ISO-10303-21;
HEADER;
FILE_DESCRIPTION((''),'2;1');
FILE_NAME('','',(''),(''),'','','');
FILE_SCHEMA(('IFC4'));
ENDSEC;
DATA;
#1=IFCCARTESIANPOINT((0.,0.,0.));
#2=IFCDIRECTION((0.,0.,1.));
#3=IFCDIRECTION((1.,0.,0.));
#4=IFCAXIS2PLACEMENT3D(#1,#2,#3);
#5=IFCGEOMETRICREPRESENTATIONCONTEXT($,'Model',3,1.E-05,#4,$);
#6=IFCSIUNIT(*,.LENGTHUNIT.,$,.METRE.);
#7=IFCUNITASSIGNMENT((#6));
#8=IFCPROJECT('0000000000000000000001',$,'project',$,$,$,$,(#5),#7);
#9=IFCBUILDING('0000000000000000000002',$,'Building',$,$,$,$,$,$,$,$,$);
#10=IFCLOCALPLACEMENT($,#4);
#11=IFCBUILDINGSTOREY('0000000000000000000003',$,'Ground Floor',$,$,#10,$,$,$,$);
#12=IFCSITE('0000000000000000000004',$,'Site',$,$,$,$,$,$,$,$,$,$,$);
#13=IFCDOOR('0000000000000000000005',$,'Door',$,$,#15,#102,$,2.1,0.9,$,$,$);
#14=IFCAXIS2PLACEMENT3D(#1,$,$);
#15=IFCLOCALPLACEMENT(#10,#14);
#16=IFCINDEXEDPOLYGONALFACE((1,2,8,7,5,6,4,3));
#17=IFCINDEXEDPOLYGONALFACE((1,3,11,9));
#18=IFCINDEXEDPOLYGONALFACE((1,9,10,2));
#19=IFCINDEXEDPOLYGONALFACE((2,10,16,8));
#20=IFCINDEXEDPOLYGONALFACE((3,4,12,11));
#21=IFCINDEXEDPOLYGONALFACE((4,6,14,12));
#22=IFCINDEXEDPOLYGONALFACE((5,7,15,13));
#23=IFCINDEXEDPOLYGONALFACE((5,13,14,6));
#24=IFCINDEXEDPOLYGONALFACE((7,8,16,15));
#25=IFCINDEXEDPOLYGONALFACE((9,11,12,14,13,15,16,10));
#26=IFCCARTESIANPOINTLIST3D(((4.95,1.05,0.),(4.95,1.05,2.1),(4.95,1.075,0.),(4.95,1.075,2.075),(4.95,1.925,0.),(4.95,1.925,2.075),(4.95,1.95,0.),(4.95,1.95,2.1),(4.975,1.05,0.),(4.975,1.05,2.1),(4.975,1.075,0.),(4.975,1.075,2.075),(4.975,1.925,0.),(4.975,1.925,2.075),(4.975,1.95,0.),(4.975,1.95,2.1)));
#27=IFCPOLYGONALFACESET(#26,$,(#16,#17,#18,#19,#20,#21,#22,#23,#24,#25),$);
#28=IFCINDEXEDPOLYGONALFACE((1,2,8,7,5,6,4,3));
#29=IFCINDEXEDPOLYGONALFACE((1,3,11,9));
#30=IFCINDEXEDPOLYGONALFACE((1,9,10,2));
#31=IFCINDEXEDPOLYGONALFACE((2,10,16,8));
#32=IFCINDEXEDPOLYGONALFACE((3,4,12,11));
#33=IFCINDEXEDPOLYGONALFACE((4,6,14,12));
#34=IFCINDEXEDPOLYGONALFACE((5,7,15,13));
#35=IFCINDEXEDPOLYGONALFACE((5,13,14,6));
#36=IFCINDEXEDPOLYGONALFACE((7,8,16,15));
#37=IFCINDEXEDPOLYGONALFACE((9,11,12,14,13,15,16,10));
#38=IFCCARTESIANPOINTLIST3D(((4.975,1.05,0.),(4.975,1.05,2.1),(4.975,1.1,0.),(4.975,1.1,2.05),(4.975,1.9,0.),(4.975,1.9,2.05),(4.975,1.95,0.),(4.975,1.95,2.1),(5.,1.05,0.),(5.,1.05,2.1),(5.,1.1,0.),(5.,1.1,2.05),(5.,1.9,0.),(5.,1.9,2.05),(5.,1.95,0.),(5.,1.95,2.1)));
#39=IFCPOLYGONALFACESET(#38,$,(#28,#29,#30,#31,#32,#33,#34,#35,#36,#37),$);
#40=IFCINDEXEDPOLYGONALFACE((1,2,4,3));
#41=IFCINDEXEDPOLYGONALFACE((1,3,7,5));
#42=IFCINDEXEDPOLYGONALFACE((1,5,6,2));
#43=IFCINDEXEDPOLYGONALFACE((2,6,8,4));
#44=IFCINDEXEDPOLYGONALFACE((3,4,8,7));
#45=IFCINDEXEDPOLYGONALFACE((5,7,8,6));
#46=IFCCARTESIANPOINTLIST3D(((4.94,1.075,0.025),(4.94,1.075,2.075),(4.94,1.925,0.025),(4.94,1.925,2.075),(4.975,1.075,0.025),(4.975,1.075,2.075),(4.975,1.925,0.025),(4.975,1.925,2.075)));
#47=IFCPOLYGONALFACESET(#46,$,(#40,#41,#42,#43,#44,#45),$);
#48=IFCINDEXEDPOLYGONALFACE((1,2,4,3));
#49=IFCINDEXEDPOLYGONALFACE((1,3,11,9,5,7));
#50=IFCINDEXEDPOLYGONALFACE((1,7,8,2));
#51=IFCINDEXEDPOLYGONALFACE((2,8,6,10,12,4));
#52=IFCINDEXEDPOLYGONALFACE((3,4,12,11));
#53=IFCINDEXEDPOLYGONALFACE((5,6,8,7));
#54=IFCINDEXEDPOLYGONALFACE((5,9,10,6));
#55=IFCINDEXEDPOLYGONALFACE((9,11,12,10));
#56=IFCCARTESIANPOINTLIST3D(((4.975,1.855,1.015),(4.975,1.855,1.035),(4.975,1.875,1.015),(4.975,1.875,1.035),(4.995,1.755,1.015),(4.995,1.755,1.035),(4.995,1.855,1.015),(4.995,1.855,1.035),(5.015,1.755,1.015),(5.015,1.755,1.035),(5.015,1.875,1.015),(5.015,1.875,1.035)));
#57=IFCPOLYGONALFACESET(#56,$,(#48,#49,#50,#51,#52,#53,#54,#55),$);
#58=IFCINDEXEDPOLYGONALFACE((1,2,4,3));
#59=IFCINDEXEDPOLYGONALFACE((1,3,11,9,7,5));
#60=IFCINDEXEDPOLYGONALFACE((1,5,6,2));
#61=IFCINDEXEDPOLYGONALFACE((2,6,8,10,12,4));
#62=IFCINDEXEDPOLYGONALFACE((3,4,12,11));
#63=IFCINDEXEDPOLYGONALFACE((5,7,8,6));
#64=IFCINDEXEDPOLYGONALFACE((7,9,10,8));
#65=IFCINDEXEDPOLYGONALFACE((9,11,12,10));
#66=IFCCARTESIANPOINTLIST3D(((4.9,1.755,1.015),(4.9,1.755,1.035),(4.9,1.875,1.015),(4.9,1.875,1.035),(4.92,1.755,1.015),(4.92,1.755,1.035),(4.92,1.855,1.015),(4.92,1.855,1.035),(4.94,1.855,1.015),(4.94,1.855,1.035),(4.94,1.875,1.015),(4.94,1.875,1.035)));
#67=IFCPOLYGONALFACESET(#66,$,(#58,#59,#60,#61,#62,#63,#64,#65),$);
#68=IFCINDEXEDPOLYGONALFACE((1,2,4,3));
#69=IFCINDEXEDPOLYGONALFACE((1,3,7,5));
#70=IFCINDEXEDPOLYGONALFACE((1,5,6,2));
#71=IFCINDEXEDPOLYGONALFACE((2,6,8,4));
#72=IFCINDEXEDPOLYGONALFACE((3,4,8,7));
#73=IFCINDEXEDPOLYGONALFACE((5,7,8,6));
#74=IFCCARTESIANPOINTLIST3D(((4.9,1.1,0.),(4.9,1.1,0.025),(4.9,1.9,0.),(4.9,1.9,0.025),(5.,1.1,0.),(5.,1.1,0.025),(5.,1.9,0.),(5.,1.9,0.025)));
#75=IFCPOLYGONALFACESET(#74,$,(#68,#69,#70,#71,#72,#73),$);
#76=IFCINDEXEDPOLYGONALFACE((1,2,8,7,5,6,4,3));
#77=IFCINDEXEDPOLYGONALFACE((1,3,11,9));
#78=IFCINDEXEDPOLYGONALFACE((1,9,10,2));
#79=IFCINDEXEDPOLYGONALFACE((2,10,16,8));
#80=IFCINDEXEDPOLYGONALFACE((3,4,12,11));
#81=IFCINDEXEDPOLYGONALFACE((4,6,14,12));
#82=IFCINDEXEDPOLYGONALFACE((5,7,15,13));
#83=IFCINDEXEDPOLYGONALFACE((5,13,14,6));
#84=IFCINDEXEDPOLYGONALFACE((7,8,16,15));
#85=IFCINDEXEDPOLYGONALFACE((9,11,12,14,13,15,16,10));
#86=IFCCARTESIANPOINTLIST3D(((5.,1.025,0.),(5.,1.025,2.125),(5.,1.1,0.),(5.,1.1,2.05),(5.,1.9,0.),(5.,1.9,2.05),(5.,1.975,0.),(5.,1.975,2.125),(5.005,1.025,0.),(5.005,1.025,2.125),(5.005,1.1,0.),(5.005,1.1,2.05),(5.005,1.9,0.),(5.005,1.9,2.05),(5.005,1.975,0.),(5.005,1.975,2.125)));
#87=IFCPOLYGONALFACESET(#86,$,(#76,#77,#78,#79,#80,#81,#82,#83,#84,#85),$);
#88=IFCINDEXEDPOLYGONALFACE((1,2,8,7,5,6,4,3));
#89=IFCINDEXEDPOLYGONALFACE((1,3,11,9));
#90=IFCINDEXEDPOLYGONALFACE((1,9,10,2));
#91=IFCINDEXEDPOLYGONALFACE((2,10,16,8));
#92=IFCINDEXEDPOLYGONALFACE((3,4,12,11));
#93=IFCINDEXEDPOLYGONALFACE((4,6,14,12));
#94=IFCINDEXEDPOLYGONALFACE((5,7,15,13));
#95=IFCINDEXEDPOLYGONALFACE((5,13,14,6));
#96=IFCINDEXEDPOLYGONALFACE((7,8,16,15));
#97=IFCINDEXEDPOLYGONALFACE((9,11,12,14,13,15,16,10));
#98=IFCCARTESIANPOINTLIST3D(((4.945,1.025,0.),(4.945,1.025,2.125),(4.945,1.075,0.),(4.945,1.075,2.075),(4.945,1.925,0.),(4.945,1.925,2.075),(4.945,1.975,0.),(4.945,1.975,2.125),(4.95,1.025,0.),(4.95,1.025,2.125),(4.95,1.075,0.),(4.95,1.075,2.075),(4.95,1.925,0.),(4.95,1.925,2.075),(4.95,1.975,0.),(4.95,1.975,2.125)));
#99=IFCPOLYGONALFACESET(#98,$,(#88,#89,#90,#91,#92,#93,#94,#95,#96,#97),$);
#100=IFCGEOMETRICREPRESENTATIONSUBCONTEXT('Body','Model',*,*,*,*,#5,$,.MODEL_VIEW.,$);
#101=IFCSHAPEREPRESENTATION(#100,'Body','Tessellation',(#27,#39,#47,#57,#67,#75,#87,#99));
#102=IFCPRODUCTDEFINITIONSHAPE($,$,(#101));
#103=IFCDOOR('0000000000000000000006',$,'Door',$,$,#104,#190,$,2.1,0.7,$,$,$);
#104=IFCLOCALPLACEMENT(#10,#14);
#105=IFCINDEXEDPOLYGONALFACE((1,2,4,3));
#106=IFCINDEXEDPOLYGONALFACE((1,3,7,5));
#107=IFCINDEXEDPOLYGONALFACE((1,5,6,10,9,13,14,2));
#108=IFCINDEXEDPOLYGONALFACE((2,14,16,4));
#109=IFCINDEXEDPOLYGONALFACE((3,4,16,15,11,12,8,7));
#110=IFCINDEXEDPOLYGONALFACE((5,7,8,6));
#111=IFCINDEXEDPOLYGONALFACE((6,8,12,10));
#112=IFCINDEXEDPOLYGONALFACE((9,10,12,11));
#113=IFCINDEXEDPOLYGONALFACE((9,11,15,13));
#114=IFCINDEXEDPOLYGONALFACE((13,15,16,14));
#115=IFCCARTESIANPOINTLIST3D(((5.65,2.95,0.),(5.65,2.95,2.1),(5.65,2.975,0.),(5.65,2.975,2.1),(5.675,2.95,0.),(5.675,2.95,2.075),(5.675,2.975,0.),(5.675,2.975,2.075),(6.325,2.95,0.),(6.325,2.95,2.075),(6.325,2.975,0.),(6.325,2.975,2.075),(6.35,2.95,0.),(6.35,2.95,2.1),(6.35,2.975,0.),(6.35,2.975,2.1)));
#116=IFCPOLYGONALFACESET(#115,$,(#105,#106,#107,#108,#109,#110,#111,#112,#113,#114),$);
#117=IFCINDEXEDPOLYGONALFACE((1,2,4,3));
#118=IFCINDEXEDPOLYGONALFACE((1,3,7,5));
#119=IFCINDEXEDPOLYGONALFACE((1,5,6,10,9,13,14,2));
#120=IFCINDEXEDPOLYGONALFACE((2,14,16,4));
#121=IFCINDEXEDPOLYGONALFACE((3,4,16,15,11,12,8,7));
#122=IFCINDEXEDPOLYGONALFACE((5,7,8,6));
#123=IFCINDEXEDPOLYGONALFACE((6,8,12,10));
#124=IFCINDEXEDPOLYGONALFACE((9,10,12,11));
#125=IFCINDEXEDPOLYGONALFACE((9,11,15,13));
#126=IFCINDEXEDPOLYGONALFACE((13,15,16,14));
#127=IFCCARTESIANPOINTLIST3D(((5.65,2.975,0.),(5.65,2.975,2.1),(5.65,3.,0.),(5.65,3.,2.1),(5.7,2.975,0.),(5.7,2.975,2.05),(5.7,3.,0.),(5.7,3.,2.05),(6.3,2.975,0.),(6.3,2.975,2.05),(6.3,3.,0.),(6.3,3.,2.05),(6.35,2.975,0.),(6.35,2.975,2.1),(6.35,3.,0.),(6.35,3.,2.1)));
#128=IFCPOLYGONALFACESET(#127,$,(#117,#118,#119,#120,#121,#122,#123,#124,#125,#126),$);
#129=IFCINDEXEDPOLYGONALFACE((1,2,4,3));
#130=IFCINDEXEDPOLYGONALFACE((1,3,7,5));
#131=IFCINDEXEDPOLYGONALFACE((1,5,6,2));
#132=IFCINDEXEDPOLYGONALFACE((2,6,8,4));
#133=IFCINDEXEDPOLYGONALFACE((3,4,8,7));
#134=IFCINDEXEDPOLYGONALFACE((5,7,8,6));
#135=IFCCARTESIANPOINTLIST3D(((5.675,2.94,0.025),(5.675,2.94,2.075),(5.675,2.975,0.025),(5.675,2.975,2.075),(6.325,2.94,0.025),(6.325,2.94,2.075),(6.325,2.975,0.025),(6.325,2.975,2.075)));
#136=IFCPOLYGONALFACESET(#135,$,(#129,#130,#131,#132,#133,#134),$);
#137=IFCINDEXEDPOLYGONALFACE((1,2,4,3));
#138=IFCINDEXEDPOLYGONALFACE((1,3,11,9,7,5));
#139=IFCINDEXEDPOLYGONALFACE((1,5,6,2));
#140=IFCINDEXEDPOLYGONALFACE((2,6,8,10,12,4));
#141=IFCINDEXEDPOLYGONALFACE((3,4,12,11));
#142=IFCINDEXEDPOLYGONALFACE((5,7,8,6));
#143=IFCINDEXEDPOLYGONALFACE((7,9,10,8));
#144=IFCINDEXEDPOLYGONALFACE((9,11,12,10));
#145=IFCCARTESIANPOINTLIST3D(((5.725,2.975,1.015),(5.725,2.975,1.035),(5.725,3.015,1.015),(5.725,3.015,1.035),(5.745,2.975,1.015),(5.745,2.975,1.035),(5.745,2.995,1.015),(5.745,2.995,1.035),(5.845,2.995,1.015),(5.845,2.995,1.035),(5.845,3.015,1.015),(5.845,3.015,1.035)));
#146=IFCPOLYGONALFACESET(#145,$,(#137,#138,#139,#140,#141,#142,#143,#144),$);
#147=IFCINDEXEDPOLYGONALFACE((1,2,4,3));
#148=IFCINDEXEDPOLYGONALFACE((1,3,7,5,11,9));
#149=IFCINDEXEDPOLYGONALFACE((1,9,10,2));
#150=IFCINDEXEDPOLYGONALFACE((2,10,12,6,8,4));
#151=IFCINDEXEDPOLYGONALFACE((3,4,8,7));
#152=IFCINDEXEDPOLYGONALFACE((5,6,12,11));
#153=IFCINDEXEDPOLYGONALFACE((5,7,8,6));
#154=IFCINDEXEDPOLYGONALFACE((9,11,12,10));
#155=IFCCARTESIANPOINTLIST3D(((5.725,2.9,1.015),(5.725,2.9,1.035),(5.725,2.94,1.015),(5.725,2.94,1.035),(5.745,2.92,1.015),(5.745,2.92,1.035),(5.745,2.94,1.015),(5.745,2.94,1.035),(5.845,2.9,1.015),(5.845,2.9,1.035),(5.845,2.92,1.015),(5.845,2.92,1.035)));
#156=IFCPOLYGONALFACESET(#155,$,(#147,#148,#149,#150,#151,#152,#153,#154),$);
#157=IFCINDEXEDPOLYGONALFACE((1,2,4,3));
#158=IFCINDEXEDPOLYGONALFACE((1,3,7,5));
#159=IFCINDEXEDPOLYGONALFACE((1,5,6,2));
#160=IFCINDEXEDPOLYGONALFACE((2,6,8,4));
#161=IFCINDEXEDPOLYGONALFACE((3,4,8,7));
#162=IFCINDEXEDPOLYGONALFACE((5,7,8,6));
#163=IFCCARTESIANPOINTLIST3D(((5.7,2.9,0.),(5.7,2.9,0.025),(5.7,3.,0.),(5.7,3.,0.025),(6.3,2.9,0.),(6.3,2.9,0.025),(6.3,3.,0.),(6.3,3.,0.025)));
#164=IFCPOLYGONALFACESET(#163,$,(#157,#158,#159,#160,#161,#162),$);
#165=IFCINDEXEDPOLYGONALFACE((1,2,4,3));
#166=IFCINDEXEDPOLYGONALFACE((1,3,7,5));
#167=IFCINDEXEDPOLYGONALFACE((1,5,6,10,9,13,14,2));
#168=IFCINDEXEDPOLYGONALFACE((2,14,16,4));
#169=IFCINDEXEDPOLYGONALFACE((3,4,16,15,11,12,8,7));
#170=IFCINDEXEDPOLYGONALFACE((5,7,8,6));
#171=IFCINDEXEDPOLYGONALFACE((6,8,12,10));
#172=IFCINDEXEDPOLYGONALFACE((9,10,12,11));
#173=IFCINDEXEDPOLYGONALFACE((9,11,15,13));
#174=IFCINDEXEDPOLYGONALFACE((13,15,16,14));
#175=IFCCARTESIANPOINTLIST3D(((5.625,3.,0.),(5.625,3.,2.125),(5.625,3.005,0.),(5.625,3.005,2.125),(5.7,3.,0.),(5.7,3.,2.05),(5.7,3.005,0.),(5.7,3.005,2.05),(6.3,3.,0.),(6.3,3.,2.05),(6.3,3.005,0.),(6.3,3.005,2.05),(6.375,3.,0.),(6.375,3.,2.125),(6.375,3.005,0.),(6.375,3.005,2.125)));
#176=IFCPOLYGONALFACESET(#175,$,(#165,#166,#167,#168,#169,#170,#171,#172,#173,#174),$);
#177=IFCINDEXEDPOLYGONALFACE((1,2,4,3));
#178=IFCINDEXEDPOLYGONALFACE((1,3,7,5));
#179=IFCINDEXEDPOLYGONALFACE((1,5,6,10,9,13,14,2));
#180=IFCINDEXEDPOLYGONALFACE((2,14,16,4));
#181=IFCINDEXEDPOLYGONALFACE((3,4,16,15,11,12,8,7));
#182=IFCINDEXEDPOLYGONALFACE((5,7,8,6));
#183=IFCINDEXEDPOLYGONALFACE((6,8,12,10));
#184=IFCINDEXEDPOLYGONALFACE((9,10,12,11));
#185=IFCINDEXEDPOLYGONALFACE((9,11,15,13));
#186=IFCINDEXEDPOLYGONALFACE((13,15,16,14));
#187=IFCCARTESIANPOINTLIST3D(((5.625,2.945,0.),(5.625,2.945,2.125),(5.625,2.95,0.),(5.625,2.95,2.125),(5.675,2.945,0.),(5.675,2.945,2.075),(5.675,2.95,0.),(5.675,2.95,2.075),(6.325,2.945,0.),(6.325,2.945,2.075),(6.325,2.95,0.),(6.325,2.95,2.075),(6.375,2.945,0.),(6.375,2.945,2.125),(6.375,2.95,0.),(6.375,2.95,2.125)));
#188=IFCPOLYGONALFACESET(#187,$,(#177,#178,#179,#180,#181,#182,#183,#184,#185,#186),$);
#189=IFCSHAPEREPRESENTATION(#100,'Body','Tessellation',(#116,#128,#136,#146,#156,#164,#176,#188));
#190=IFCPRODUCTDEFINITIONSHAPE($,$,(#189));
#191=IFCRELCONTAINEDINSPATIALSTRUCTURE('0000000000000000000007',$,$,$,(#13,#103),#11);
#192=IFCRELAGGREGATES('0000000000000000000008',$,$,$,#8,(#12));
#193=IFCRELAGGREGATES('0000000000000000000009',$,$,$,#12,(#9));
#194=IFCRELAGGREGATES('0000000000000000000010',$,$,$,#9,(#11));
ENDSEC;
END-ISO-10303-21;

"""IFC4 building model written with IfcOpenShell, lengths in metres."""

from ifc_helpers import new_model, si_unit, frame, origin_with_axes, place, context, subcontext, project, spatial, line, indexed_curve, outline, extrude, element, save


model = new_model("IFC4")

# Units and contexts
model_context = context("Model", 3, precision=1e-05, world=origin_with_axes())
body_context = subcontext(model_context, "Body", "Model", "MODEL_VIEW")
ifc_project = project(units=[si_unit("LENGTHUNIT", "METRE")], contexts=[model_context])

# Site, building, storey
site = spatial("IfcSite", under=ifc_project, Name="Site")
building = spatial("IfcBuilding", under=site, Name="Building")
storey_placement = place(None, origin_with_axes())
storey = spatial("IfcBuildingStorey", under=building, at=storey_placement, Name="Ground Floor")

# Doors
door_1_placement = place(storey_placement, frame((5.0, 1.05, 0.0), z_axis=(0.0, 0.0, 1.0), x_axis=(0.0, 1.0, 0.0)))
element("IfcDoor", 1, at=door_1_placement, inside=storey, Name="Door", OverallHeight=2.1, OverallWidth=0.9, context=body_context, shape_type="SweptSolid", body=[
    extrude(outline(indexed_curve([(0.0, 0.0), (0.0, 2.1), (0.9, 2.1), (0.9, 0.0), (0.875, 0.0), (0.875, 2.075), (0.025, 2.075), (0.025, 0.0)], segments=[line(1, 2, 3, 4, 5, 6, 7, 8, 1)])), frame((0.0, 0.025, 0.0), z_axis=(0.0, -1.0, 0.0), x_axis=(1.0, 0.0, 0.0)), (0.0, 0.0, -1.0), 0.025),
    extrude(outline(indexed_curve([(0.0, 0.0), (0.0, 2.1), (0.9, 2.1), (0.9, 0.0), (0.85, 0.0), (0.85, 2.05), (0.05, 2.05), (0.05, 0.0)], segments=[line(1, 2, 3, 4, 5, 6, 7, 8, 1)])), frame((0.0, 0.0, 0.0), z_axis=(0.0, -1.0, 0.0), x_axis=(1.0, 0.0, 0.0)), (0.0, 0.0, -1.0), 0.025),
    extrude(outline(indexed_curve([(0.0, 0.0), (0.85, 0.0), (0.85, 0.035), (0.0, 0.035)], segments=[line(1, 2, 3, 4, 1)])), frame((0.025, 0.025, 0.025), z_axis=(0.0, 0.0, 1.0), x_axis=(1.0, 0.0, 0.0)), (0.0, 0.0, 1.0), 2.05),
    extrude(outline(indexed_curve([(0.0, 0.0), (0.0, -0.04), (-0.12, -0.04), (-0.12, -0.02), (-0.02, -0.02), (-0.02, 0.0)], segments=[line(1, 2, 3, 4, 5, 6, 1)])), frame((0.825, 0.025, 1.015), z_axis=(0.0, 0.0, 1.0), x_axis=(1.0, 0.0, 0.0)), (0.0, 0.0, 1.0), 0.02),
    extrude(outline(indexed_curve([(0.0, 0.0), (0.0, 0.04), (-0.12, 0.04), (-0.12, 0.02), (-0.02, 0.02), (-0.02, 0.0)], segments=[line(1, 2, 3, 4, 5, 6, 1)])), frame((0.825, 0.06, 1.015), z_axis=(0.0, 0.0, 1.0), x_axis=(1.0, 0.0, 0.0)), (0.0, 0.0, 1.0), 0.02),
    extrude(outline(indexed_curve([(0.0, 0.0), (0.8, 0.0), (0.8, 0.1), (0.0, 0.1)], segments=[line(1, 2, 3, 4, 1)])), frame((0.05, 0.0, 0.0), z_axis=(0.0, 0.0, 1.0), x_axis=(1.0, 0.0, 0.0)), (0.0, 0.0, 1.0), 0.025),
    extrude(outline(indexed_curve([(0.0, 0.0), (0.0, 2.125), (0.95, 2.125), (0.95, 0.0), (0.875, 0.0), (0.875, 2.05), (0.075, 2.05), (0.075, 0.0)], segments=[line(1, 2, 3, 4, 5, 6, 7, 8, 1)])), frame((-0.025, -0.005, 0.0), z_axis=(0.0, -1.0, 0.0), x_axis=(1.0, 0.0, 0.0)), (0.0, 0.0, -1.0), 0.005),
    extrude(outline(indexed_curve([(0.0, 0.0), (0.0, 2.125), (0.95, 2.125), (0.95, 0.0), (0.9, 0.0), (0.9, 2.075), (0.05, 2.075), (0.05, 0.0)], segments=[line(1, 2, 3, 4, 5, 6, 7, 8, 1)])), frame((-0.025, 0.05, 0.0), z_axis=(0.0, -1.0, 0.0), x_axis=(1.0, 0.0, 0.0)), (0.0, 0.0, -1.0), 0.005),
])
door_2_placement = place(storey_placement, frame((6.35, 3.0, 0.0), z_axis=(0.0, 0.0, 1.0), x_axis=(-1.0, 0.0, 0.0)))
element("IfcDoor", 2, at=door_2_placement, inside=storey, Name="Door", OverallHeight=2.1, OverallWidth=0.7, context=body_context, shape_type="SweptSolid", body=[
    extrude(outline(indexed_curve([(0.0, 0.0), (0.0, 2.1), (0.7, 2.1), (0.7, 0.0), (0.675, 0.0), (0.675, 2.075), (0.025, 2.075), (0.025, 0.0)], segments=[line(1, 2, 3, 4, 5, 6, 7, 8, 1)])), frame((0.0, 0.025, 0.0), z_axis=(0.0, -1.0, 0.0), x_axis=(1.0, 0.0, 0.0)), (0.0, 0.0, -1.0), 0.025),
    extrude(outline(indexed_curve([(0.0, 0.0), (0.0, 2.1), (0.7, 2.1), (0.7, 0.0), (0.65, 0.0), (0.65, 2.05), (0.05, 2.05), (0.05, 0.0)], segments=[line(1, 2, 3, 4, 5, 6, 7, 8, 1)])), frame((0.0, 0.0, 0.0), z_axis=(0.0, -1.0, 0.0), x_axis=(1.0, 0.0, 0.0)), (0.0, 0.0, -1.0), 0.025),
    extrude(outline(indexed_curve([(0.0, 0.0), (0.65, 0.0), (0.65, 0.035), (0.0, 0.035)], segments=[line(1, 2, 3, 4, 1)])), frame((0.025, 0.025, 0.025), z_axis=(0.0, 0.0, 1.0), x_axis=(1.0, 0.0, 0.0)), (0.0, 0.0, 1.0), 2.05),
    extrude(outline(indexed_curve([(0.0, 0.0), (0.0, -0.04), (-0.12, -0.04), (-0.12, -0.02), (-0.02, -0.02), (-0.02, 0.0)], segments=[line(1, 2, 3, 4, 5, 6, 1)])), frame((0.625, 0.025, 1.015), z_axis=(0.0, 0.0, 1.0), x_axis=(1.0, 0.0, 0.0)), (0.0, 0.0, 1.0), 0.02),
    extrude(outline(indexed_curve([(0.0, 0.0), (0.0, 0.04), (-0.12, 0.04), (-0.12, 0.02), (-0.02, 0.02), (-0.02, 0.0)], segments=[line(1, 2, 3, 4, 5, 6, 1)])), frame((0.625, 0.06, 1.015), z_axis=(0.0, 0.0, 1.0), x_axis=(1.0, 0.0, 0.0)), (0.0, 0.0, 1.0), 0.02),
    extrude(outline(indexed_curve([(0.0, 0.0), (0.6, 0.0), (0.6, 0.1), (0.0, 0.1)], segments=[line(1, 2, 3, 4, 1)])), frame((0.05, 0.0, 0.0), z_axis=(0.0, 0.0, 1.0), x_axis=(1.0, 0.0, 0.0)), (0.0, 0.0, 1.0), 0.025),
    extrude(outline(indexed_curve([(0.0, 0.0), (0.0, 2.125), (0.75, 2.125), (0.75, 0.0), (0.675, 0.0), (0.675, 2.05), (0.075, 2.05), (0.075, 0.0)], segments=[line(1, 2, 3, 4, 5, 6, 7, 8, 1)])), frame((-0.025, -0.005, 0.0), z_axis=(0.0, -1.0, 0.0), x_axis=(1.0, 0.0, 0.0)), (0.0, 0.0, -1.0), 0.005),
    extrude(outline(indexed_curve([(0.0, 0.0), (0.0, 2.125), (0.75, 2.125), (0.75, 0.0), (0.7, 0.0), (0.7, 2.075), (0.05, 2.075), (0.05, 0.0)], segments=[line(1, 2, 3, 4, 5, 6, 7, 8, 1)])), frame((-0.025, 0.05, 0.0), z_axis=(0.0, -1.0, 0.0), x_axis=(1.0, 0.0, 0.0)), (0.0, 0.0, -1.0), 0.005),
])

save(model, "model.ifc")
